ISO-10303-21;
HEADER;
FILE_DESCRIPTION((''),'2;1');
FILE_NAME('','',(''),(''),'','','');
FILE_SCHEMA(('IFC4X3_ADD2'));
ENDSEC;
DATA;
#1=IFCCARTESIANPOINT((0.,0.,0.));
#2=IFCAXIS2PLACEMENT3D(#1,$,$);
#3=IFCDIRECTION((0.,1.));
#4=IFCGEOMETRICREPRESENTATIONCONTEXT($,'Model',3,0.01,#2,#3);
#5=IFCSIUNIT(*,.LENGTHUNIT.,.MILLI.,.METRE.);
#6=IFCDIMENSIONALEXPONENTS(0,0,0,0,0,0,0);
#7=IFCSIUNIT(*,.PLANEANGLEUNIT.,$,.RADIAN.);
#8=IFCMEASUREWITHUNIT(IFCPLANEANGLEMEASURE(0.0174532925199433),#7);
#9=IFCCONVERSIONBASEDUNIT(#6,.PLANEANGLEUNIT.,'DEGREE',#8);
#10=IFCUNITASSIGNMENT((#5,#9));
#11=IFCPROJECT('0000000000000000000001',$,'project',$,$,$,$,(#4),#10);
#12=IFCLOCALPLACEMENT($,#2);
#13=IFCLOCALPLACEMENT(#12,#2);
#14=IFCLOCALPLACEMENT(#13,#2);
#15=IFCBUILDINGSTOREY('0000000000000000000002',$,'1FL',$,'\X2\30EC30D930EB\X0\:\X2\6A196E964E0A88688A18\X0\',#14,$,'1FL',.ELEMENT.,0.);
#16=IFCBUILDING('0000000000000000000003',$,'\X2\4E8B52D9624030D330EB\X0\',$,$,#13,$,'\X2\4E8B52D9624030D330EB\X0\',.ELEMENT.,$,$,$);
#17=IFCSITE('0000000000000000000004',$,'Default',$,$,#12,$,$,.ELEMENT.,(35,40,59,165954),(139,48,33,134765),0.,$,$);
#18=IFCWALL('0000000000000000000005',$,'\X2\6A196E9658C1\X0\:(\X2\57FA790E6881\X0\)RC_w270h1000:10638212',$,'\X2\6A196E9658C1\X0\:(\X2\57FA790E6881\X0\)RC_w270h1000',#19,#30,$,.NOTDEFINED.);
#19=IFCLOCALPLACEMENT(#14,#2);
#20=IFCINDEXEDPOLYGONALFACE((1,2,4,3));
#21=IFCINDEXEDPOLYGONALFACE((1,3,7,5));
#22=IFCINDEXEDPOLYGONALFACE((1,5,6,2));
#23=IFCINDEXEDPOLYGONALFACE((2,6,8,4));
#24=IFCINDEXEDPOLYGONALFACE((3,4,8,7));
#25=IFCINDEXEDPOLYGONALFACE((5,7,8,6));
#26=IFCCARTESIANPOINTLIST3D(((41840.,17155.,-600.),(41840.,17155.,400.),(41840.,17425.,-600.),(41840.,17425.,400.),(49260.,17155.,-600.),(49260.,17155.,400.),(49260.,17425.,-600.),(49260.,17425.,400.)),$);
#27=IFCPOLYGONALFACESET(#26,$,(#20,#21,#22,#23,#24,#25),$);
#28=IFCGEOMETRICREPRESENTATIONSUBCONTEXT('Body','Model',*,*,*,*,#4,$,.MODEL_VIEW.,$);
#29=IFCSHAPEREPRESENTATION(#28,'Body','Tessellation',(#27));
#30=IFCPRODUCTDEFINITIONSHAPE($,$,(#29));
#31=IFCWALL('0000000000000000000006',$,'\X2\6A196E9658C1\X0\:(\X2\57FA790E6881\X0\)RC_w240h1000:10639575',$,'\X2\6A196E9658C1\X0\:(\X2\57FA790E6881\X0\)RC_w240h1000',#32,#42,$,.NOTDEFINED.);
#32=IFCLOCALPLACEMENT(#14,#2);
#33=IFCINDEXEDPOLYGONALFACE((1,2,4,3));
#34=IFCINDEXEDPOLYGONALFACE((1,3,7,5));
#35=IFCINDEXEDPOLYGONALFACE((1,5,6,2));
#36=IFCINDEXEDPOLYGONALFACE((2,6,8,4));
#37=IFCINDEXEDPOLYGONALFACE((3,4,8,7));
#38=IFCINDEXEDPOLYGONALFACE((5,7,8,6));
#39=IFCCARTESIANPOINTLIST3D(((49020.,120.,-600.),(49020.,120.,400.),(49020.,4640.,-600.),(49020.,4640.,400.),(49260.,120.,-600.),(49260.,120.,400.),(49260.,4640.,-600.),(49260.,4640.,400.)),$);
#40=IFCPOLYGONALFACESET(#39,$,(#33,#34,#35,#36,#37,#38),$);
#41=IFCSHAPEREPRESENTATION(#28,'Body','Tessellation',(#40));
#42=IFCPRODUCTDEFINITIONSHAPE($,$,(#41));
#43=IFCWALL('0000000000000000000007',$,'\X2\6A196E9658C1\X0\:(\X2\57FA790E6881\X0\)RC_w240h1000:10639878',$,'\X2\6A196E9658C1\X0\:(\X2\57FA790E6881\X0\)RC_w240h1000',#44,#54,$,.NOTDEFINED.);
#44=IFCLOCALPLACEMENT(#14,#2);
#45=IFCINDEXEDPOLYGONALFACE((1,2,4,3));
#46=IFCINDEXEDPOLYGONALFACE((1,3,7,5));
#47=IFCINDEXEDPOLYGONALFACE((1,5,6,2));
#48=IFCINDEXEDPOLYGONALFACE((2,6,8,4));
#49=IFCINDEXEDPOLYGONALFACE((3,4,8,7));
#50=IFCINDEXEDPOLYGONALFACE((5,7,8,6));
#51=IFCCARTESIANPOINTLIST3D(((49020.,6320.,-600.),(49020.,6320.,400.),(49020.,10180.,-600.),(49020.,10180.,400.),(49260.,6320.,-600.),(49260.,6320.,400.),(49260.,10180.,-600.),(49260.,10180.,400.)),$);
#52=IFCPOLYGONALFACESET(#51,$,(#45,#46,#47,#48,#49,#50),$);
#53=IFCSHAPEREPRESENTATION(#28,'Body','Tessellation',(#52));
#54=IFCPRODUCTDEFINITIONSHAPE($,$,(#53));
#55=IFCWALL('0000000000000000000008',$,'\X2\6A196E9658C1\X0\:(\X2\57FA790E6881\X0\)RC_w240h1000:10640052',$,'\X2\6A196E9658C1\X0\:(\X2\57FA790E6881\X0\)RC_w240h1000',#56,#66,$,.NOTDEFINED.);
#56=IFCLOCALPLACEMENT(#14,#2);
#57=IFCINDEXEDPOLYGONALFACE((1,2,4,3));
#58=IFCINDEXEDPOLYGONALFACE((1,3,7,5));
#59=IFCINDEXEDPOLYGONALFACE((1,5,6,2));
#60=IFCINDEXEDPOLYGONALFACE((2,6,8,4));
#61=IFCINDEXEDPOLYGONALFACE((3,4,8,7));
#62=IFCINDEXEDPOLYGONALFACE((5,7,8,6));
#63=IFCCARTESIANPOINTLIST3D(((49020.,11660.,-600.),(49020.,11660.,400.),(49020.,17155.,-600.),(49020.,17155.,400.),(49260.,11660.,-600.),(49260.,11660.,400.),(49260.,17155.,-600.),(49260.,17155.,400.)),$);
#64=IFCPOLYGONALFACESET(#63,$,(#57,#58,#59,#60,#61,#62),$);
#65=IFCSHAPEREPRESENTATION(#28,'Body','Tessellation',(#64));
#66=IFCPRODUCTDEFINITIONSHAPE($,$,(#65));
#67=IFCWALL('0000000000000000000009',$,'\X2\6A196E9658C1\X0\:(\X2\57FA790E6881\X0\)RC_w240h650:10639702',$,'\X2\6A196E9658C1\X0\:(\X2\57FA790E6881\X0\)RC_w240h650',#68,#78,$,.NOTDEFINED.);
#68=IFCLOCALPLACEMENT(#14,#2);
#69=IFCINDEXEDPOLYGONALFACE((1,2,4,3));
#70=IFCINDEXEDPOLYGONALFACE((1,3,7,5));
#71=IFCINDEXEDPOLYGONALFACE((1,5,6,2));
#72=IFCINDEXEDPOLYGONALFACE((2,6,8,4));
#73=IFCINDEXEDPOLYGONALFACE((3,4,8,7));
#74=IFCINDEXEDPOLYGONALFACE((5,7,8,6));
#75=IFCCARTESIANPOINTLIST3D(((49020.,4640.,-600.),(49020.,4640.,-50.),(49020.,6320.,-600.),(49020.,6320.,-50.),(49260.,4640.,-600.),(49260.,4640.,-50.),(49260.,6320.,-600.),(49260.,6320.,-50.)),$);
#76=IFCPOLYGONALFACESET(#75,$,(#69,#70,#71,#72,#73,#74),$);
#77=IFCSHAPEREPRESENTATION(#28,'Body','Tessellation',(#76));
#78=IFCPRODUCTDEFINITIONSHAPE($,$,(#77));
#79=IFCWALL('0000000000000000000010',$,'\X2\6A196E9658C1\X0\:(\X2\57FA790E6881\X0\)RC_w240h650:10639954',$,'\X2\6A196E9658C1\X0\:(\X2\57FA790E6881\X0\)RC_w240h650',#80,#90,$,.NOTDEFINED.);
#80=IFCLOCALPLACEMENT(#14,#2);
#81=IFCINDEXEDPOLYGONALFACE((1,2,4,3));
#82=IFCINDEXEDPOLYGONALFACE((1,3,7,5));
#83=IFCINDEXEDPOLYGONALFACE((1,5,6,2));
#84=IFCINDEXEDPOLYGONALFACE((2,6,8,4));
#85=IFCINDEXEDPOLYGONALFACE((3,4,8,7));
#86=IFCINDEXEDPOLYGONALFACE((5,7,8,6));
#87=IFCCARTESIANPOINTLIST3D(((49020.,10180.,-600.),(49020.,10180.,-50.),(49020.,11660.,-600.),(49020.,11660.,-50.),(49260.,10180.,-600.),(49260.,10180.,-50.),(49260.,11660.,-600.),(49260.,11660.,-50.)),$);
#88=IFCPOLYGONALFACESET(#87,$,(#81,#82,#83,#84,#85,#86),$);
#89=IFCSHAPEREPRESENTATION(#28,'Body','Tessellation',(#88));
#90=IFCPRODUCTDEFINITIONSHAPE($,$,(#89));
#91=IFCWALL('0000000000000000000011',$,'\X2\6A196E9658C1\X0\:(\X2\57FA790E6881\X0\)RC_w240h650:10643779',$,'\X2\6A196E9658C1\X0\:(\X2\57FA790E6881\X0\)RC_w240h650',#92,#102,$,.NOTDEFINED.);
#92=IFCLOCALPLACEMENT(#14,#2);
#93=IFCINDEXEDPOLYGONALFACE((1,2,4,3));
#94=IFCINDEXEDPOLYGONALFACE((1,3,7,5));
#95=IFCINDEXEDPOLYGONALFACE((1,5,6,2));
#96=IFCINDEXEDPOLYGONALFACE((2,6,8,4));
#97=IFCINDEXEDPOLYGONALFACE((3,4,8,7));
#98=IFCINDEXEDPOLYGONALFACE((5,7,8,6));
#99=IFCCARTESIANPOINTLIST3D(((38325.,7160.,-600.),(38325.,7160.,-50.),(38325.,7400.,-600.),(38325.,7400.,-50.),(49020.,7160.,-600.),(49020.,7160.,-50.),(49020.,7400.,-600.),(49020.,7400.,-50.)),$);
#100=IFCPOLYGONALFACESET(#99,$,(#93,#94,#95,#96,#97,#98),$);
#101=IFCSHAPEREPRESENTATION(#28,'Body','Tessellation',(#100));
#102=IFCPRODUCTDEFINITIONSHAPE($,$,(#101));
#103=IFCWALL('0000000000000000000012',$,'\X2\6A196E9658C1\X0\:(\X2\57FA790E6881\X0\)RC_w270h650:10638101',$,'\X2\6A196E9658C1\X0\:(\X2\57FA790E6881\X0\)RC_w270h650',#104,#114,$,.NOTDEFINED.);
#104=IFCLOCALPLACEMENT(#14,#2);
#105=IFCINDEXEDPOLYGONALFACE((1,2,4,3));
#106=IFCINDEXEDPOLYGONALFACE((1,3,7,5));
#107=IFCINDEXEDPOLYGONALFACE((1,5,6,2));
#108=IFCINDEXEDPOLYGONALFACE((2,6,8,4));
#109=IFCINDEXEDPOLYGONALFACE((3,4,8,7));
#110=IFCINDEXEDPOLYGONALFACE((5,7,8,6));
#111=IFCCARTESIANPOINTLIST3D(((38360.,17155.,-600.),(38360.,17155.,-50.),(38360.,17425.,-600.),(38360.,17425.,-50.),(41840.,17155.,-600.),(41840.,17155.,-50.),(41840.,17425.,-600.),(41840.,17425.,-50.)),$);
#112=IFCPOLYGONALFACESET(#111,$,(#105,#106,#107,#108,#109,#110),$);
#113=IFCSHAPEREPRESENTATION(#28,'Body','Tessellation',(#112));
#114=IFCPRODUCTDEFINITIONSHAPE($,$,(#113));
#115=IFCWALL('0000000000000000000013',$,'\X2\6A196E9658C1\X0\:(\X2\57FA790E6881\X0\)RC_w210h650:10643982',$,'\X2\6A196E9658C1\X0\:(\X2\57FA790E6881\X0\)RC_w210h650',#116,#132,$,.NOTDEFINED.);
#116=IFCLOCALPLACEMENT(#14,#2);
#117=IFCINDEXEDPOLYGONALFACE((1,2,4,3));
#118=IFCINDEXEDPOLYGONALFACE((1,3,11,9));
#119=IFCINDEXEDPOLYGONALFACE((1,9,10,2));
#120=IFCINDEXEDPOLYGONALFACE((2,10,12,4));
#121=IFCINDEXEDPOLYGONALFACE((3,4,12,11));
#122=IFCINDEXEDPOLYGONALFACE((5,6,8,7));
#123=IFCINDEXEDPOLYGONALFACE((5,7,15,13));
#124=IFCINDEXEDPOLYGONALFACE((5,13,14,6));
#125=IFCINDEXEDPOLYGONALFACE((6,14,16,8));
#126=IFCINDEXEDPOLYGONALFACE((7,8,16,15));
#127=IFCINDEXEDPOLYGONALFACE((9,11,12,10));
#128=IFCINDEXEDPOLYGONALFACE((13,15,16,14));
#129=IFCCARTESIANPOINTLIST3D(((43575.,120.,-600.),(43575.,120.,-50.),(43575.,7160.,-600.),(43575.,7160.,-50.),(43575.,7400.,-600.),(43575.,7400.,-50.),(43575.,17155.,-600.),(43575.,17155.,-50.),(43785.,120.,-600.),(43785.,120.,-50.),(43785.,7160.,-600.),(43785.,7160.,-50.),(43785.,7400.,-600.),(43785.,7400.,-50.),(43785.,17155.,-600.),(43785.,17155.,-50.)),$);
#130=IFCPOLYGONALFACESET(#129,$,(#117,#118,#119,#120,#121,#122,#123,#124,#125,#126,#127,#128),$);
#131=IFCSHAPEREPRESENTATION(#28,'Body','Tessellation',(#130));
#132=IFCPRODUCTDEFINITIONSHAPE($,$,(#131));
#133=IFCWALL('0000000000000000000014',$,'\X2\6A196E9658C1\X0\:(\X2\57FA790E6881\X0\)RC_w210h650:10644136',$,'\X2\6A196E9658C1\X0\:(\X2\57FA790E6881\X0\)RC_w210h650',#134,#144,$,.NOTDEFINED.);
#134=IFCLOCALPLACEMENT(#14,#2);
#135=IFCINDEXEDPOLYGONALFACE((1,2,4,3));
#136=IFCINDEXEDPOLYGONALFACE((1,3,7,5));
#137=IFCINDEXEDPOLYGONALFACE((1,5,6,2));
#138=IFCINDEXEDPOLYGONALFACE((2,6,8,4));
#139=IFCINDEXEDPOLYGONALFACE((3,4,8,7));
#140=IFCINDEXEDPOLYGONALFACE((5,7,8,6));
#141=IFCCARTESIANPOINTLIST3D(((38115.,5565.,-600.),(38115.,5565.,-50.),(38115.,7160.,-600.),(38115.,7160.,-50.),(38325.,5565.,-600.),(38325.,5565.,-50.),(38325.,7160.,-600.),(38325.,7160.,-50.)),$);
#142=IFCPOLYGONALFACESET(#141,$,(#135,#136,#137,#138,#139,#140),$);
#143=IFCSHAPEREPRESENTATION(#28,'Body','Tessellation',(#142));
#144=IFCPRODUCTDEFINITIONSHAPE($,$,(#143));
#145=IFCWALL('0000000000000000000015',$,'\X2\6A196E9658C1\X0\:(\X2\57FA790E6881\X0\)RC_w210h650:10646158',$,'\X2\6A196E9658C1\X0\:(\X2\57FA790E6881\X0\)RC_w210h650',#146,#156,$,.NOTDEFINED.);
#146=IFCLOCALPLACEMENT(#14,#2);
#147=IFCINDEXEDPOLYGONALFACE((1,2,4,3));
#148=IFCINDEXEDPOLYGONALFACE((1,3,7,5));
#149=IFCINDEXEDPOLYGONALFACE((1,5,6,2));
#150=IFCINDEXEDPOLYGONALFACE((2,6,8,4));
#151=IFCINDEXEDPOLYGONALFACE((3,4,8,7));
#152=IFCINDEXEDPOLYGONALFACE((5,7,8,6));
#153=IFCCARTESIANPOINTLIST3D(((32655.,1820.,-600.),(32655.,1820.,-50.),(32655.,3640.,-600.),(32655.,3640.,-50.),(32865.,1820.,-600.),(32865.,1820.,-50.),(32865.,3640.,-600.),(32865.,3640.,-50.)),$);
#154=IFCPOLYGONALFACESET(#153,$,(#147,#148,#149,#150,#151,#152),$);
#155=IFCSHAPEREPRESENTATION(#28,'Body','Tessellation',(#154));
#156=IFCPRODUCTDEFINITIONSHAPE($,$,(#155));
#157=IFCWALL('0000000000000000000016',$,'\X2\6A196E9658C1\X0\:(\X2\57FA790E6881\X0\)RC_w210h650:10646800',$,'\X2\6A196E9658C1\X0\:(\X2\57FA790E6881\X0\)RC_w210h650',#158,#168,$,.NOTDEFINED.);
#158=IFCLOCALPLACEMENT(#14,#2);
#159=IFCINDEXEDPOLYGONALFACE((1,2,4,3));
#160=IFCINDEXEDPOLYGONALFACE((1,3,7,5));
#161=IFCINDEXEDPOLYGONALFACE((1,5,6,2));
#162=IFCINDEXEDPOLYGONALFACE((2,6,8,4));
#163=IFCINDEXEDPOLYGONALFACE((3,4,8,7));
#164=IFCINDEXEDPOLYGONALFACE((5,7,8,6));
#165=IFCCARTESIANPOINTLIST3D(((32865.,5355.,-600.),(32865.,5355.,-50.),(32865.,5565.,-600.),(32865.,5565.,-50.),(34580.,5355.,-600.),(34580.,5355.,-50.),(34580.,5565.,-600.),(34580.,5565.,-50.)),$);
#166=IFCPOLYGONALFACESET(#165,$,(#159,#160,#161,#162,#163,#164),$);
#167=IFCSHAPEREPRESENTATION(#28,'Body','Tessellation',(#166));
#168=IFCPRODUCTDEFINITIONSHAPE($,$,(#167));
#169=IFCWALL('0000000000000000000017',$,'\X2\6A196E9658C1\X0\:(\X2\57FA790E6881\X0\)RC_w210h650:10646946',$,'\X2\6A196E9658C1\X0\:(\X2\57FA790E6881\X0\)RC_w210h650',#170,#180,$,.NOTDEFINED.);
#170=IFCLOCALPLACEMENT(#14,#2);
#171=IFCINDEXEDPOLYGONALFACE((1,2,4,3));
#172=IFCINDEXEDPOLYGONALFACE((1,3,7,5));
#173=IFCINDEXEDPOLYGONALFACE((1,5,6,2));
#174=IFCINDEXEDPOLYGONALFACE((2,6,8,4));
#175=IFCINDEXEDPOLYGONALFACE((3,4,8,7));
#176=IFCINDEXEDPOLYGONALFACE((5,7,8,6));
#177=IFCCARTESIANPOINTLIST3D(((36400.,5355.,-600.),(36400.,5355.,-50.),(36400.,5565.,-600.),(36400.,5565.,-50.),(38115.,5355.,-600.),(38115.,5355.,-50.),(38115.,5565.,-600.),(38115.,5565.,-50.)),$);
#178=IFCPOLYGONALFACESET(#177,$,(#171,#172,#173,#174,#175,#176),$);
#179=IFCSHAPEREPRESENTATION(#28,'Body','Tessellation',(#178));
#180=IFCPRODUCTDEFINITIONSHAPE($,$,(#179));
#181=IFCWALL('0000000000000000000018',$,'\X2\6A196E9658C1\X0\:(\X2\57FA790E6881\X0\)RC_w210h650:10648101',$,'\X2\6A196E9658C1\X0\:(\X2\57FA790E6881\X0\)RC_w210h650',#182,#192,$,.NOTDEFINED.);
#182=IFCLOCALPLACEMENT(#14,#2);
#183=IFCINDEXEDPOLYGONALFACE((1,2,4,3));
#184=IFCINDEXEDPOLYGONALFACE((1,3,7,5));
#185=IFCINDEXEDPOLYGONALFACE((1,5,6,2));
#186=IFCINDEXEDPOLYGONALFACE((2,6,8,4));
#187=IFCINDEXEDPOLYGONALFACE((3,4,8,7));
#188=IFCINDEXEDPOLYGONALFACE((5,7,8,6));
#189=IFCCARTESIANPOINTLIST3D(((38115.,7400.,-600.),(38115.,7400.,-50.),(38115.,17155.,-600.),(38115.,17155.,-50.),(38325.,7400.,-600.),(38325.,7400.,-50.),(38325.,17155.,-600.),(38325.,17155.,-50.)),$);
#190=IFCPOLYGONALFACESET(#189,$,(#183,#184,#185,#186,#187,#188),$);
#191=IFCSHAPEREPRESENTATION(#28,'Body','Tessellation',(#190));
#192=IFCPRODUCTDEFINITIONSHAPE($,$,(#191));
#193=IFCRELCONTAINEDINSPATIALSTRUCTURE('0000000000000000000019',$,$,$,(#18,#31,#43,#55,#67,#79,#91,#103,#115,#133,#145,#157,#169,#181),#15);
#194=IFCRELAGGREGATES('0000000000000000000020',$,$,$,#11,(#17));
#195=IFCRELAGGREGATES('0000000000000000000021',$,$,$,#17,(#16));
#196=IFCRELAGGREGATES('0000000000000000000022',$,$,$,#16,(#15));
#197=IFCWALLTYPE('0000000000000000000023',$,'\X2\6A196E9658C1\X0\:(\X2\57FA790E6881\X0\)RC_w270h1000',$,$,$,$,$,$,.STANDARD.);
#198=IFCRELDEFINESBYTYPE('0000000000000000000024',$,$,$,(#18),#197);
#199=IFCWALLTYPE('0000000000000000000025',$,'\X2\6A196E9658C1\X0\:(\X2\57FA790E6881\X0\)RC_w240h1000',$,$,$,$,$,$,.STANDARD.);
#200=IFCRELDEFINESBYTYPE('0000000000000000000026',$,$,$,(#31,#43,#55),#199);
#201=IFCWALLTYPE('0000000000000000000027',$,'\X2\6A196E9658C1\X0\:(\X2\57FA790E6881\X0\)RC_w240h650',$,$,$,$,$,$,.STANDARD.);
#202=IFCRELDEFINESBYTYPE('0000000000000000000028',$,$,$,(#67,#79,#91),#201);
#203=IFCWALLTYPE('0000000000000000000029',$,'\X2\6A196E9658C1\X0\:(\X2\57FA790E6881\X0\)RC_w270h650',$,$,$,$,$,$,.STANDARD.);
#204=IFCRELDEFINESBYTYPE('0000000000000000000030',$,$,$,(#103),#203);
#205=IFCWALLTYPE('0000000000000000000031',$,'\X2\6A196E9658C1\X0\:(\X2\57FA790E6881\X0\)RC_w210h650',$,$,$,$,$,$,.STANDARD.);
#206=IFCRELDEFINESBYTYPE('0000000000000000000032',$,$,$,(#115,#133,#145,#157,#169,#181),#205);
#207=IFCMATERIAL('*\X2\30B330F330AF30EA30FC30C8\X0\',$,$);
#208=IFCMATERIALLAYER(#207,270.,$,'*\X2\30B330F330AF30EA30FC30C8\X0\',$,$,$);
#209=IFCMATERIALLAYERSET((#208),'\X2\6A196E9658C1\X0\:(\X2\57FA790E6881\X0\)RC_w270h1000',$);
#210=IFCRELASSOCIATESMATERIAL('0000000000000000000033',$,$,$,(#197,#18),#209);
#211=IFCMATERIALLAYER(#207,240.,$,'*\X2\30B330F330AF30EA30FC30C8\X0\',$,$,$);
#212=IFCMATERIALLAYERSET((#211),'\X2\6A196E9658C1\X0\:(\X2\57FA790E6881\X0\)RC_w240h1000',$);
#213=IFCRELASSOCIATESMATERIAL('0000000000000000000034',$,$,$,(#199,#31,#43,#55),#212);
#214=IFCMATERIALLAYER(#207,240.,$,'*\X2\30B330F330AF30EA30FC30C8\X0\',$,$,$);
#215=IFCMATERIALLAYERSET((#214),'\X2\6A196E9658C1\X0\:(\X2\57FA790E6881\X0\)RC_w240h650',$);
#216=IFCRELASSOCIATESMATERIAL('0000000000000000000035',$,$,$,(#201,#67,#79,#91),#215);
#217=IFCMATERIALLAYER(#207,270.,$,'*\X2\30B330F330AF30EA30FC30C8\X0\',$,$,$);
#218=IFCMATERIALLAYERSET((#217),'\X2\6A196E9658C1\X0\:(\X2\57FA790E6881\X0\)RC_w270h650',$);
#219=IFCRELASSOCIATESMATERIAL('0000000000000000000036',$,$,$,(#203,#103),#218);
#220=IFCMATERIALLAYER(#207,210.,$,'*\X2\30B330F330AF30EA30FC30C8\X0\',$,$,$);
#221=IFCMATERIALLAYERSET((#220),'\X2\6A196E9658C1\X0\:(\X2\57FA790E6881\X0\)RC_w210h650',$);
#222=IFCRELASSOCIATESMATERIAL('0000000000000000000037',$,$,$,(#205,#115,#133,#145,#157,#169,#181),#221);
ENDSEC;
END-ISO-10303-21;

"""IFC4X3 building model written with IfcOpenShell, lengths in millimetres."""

from ifc_helpers import new_model, entity, si_unit, converted_unit, direction, frame, frame_2d, origin, origin_2d_with_axis, place, context, subcontext, project, spatial, rectangle, extrude, material, layer, layer_set, type_object, element, save


model = new_model("IFC4X3")

# Units and contexts
model_context = context("Model", 3, precision=0.01, world=origin(), true_north=direction((0.0, 1.0)))
body_context = subcontext(model_context, "Body", "Model", "MODEL_VIEW")
ifc_project = project(units=[si_unit("LENGTHUNIT", "METRE", prefix="MILLI"), converted_unit("PLANEANGLEUNIT", "DEGREE", entity("IfcPlaneAngleMeasure", 0.0174532925199433), si_unit("PLANEANGLEUNIT", "RADIAN"), dimensions=[0, 0, 0, 0, 0, 0, 0])], contexts=[model_context])

# Site, building, storey
site_placement = place(None, origin())
site = spatial("IfcSite", under=ifc_project, at=site_placement, Name="Default", CompositionType="ELEMENT", RefLatitude=(35, 40, 59, 165954), RefLongitude=(139, 48, 33, 134765), RefElevation=0.0)
building_placement = place(site_placement, origin())
building = spatial("IfcBuilding", under=site, at=building_placement, Name="事務所ビル", LongName="事務所ビル", CompositionType="ELEMENT")
storey_placement = place(building_placement, origin())
storey = spatial("IfcBuildingStorey", under=building, at=storey_placement, Name="1FL", ObjectType="レベル:標準上表記", LongName="1FL", CompositionType="ELEMENT", Elevation=0.0)

# Walls
ifc_material_1 = material(Name="*コンクリート")
ifc_layer_1 = layer(ifc_material_1, 270.0, Name="*コンクリート")
ifc_layer_set_1 = layer_set([ifc_layer_1], Name="標準壁:(基礎梁)RC_w270h1000")
wall_type_1 = type_object("IfcWallType", Name="標準壁:(基礎梁)RC_w270h1000", PredefinedType="STANDARD", material=ifc_layer_set_1)
wall_1_placement = place(storey_placement, frame((41840.0, 17290.0, -600.0)))
element("IfcWall", 1, at=wall_1_placement, inside=storey, type_object=wall_type_1, material=ifc_layer_set_1, Name="標準壁:(基礎梁)RC_w270h1000:10638212", ObjectType="標準壁:(基礎梁)RC_w270h1000", PredefinedType="NOTDEFINED", context=body_context, shape_type="SweptSolid", body=[
    extrude(rectangle(XDim=7420.0, YDim=270.0, at=frame_2d((3710.0, 0.0), x_axis=(-1.0, 0.0))), origin(), (0.0, 0.0, 1.0), 1000.0),
])
ifc_layer_2 = layer(ifc_material_1, 240.0, Name="*コンクリート")
ifc_layer_set_2 = layer_set([ifc_layer_2], Name="標準壁:(基礎梁)RC_w240h1000")
wall_type_2 = type_object("IfcWallType", Name="標準壁:(基礎梁)RC_w240h1000", PredefinedType="STANDARD", material=ifc_layer_set_2)
wall_2_placement = place(storey_placement, frame((49140.0, 120.0, -600.0), z_axis=(0.0, 0.0, 1.0), x_axis=(0.0, 1.0, 0.0)))
element("IfcWall", 2, at=wall_2_placement, inside=storey, type_object=wall_type_2, material=ifc_layer_set_2, Name="標準壁:(基礎梁)RC_w240h1000:10639575", ObjectType="標準壁:(基礎梁)RC_w240h1000", PredefinedType="NOTDEFINED", context=body_context, shape_type="SweptSolid", body=[
    extrude(rectangle(XDim=4520.0, YDim=240.0, at=frame_2d((2260.0, 0.0), x_axis=(-1.0, 0.0))), origin(), (0.0, 0.0, 1.0), 1000.0),
])
wall_3_placement = place(storey_placement, frame((49140.0, 6320.0, -600.0), z_axis=(0.0, 0.0, 1.0), x_axis=(0.0, 1.0, 0.0)))
element("IfcWall", 3, at=wall_3_placement, inside=storey, type_object=wall_type_2, material=ifc_layer_set_2, Name="標準壁:(基礎梁)RC_w240h1000:10639878", ObjectType="標準壁:(基礎梁)RC_w240h1000", PredefinedType="NOTDEFINED", context=body_context, shape_type="SweptSolid", body=[
    extrude(rectangle(XDim=3860.0, YDim=240.0, at=frame_2d((1930.0, 0.0), x_axis=(-1.0, 0.0))), origin(), (0.0, 0.0, 1.0), 1000.0),
])
wall_4_placement = place(storey_placement, frame((49140.0, 11660.0, -600.0), z_axis=(0.0, 0.0, 1.0), x_axis=(0.0, 1.0, 0.0)))
element("IfcWall", 4, at=wall_4_placement, inside=storey, type_object=wall_type_2, material=ifc_layer_set_2, Name="標準壁:(基礎梁)RC_w240h1000:10640052", ObjectType="標準壁:(基礎梁)RC_w240h1000", PredefinedType="NOTDEFINED", context=body_context, shape_type="SweptSolid", body=[
    extrude(rectangle(XDim=5495.0, YDim=240.0, at=frame_2d((2747.5, 0.0), x_axis=(-1.0, 0.0))), origin(), (0.0, 0.0, 1.0), 1000.0),
])
ifc_layer_3 = layer(ifc_material_1, 240.0, Name="*コンクリート")
ifc_layer_set_3 = layer_set([ifc_layer_3], Name="標準壁:(基礎梁)RC_w240h650")
wall_type_3 = type_object("IfcWallType", Name="標準壁:(基礎梁)RC_w240h650", PredefinedType="STANDARD", material=ifc_layer_set_3)
wall_5_placement = place(storey_placement, frame((49140.0, 4640.0, -600.0), z_axis=(0.0, 0.0, 1.0), x_axis=(0.0, 1.0, 0.0)))
element("IfcWall", 5, at=wall_5_placement, inside=storey, type_object=wall_type_3, material=ifc_layer_set_3, Name="標準壁:(基礎梁)RC_w240h650:10639702", ObjectType="標準壁:(基礎梁)RC_w240h650", PredefinedType="NOTDEFINED", context=body_context, shape_type="SweptSolid", body=[
    extrude(rectangle(XDim=1680.0, YDim=240.0, at=frame_2d((840.0, 0.0), x_axis=(-1.0, 0.0))), origin(), (0.0, 0.0, 1.0), 550.0),
])
wall_6_placement = place(storey_placement, frame((49140.0, 10180.0, -600.0), z_axis=(0.0, 0.0, 1.0), x_axis=(0.0, 1.0, 0.0)))
element("IfcWall", 6, at=wall_6_placement, inside=storey, type_object=wall_type_3, material=ifc_layer_set_3, Name="標準壁:(基礎梁)RC_w240h650:10639954", ObjectType="標準壁:(基礎梁)RC_w240h650", PredefinedType="NOTDEFINED", context=body_context, shape_type="SweptSolid", body=[
    extrude(rectangle(XDim=1480.0, YDim=240.0, at=frame_2d((740.0, 0.0), x_axis=(-1.0, 0.0))), origin(), (0.0, 0.0, 1.0), 550.0),
])
wall_7_placement = place(storey_placement, frame((38325.0, 7280.0, -600.0)))
element("IfcWall", 7, at=wall_7_placement, inside=storey, type_object=wall_type_3, material=ifc_layer_set_3, Name="標準壁:(基礎梁)RC_w240h650:10643779", ObjectType="標準壁:(基礎梁)RC_w240h650", PredefinedType="NOTDEFINED", context=body_context, shape_type="SweptSolid", body=[
    extrude(rectangle(XDim=10695.0, YDim=240.0, at=frame_2d((5347.5, 0.0), x_axis=(-1.0, 0.0))), origin(), (0.0, 0.0, 1.0), 550.0),
])
ifc_layer_4 = layer(ifc_material_1, 270.0, Name="*コンクリート")
ifc_layer_set_4 = layer_set([ifc_layer_4], Name="標準壁:(基礎梁)RC_w270h650")
wall_type_4 = type_object("IfcWallType", Name="標準壁:(基礎梁)RC_w270h650", PredefinedType="STANDARD", material=ifc_layer_set_4)
wall_8_placement = place(storey_placement, frame((38360.0, 17290.0, -600.0)))
element("IfcWall", 8, at=wall_8_placement, inside=storey, type_object=wall_type_4, material=ifc_layer_set_4, Name="標準壁:(基礎梁)RC_w270h650:10638101", ObjectType="標準壁:(基礎梁)RC_w270h650", PredefinedType="NOTDEFINED", context=body_context, shape_type="SweptSolid", body=[
    extrude(rectangle(XDim=3480.0, YDim=270.0, at=frame_2d((1740.0, 0.0), x_axis=(-1.0, 0.0))), origin(), (0.0, 0.0, 1.0), 550.0),
])

# Wall, opening
ifc_layer_5 = layer(ifc_material_1, 210.0, Name="*コンクリート")
ifc_layer_set_5 = layer_set([ifc_layer_5], Name="標準壁:(基礎梁)RC_w210h650")
wall_type_5 = type_object("IfcWallType", Name="標準壁:(基礎梁)RC_w210h650", PredefinedType="STANDARD", material=ifc_layer_set_5)
wall_9_placement = place(storey_placement, frame((43680.0, 120.0, -600.0), z_axis=(0.0, 0.0, 1.0), x_axis=(0.0, 1.0, 0.0)))
wall_9 = element("IfcWall", 9, at=wall_9_placement, inside=storey, type_object=wall_type_5, material=ifc_layer_set_5, Name="標準壁:(基礎梁)RC_w210h650:10643982", ObjectType="標準壁:(基礎梁)RC_w210h650", PredefinedType="NOTDEFINED", context=body_context, shape_type="SweptSolid", body=[
    extrude(rectangle(XDim=17035.0, YDim=210.0, at=frame_2d((8517.5, 0.0), x_axis=(-1.0, 0.0))), origin(), (0.0, 0.0, 1.0), 550.0),
])
opening_1_placement = place(storey_placement, frame((43680.0, 120.0, -600.0), z_axis=(0.0, 0.0, 1.0), x_axis=(0.0, 1.0, 0.0)))
element("IfcOpeningElement", 10, at=opening_1_placement, cuts=wall_9, PredefinedType="OPENING", context=body_context, shape_type="SweptSolid", body=[
    extrude(rectangle(XDim=550.0, YDim=210.0, at=origin_2d_with_axis()), frame((7040.0, 0.0, 275.0), z_axis=(1.0, 0.0, 0.0), x_axis=(0.0, 0.0, -1.0)), (0.0, 0.0, 1.0), 240.0),
])

# Walls
wall_10_placement = place(storey_placement, frame((38220.0, 5565.0, -600.0), z_axis=(0.0, 0.0, 1.0), x_axis=(0.0, 1.0, 0.0)))
element("IfcWall", 11, at=wall_10_placement, inside=storey, type_object=wall_type_5, material=ifc_layer_set_5, Name="標準壁:(基礎梁)RC_w210h650:10644136", ObjectType="標準壁:(基礎梁)RC_w210h650", PredefinedType="NOTDEFINED", context=body_context, shape_type="SweptSolid", body=[
    extrude(rectangle(XDim=1595.0, YDim=210.0, at=frame_2d((797.5, 0.0), x_axis=(-1.0, 0.0))), origin(), (0.0, 0.0, 1.0), 550.0),
])
wall_11_placement = place(storey_placement, frame((32760.0, 1820.0, -600.0), z_axis=(0.0, 0.0, 1.0), x_axis=(0.0, 1.0, 0.0)))
element("IfcWall", 12, at=wall_11_placement, inside=storey, type_object=wall_type_5, material=ifc_layer_set_5, Name="標準壁:(基礎梁)RC_w210h650:10646158", ObjectType="標準壁:(基礎梁)RC_w210h650", PredefinedType="NOTDEFINED", context=body_context, shape_type="SweptSolid", body=[
    extrude(rectangle(XDim=1820.0, YDim=210.0, at=frame_2d((910.0, 0.0), x_axis=(-1.0, 0.0))), origin(), (0.0, 0.0, 1.0), 550.0),
])
for number, where, name in (
    (13, (32865.0, 5460.0, -600.0), "標準壁:(基礎梁)RC_w210h650:10646800"),
    (14, (36400.0, 5460.0, -600.0), "標準壁:(基礎梁)RC_w210h650:10646946"),
):
    element("IfcWall", number, at=place(storey_placement, frame(where)), inside=storey, type_object=wall_type_5, material=ifc_layer_set_5, Name=name, ObjectType="標準壁:(基礎梁)RC_w210h650", PredefinedType="NOTDEFINED", context=body_context, shape_type="SweptSolid", body=[
        extrude(rectangle(XDim=1715.0, YDim=210.0, at=frame_2d((857.5, 0.0), x_axis=(-1.0, 0.0))), origin(), (0.0, 0.0, 1.0), 550.0),
    ])
wall_12_placement = place(storey_placement, frame((38220.0, 7400.0, -600.0), z_axis=(0.0, 0.0, 1.0), x_axis=(0.0, 1.0, 0.0)))
element("IfcWall", 15, at=wall_12_placement, inside=storey, type_object=wall_type_5, material=ifc_layer_set_5, Name="標準壁:(基礎梁)RC_w210h650:10648101", ObjectType="標準壁:(基礎梁)RC_w210h650", PredefinedType="NOTDEFINED", context=body_context, shape_type="SweptSolid", body=[
    extrude(rectangle(XDim=9755.0, YDim=210.0, at=frame_2d((4877.5, 0.0), x_axis=(-1.0, 0.0))), origin(), (0.0, 0.0, 1.0), 550.0),
])

save(model, "model.ifc")
